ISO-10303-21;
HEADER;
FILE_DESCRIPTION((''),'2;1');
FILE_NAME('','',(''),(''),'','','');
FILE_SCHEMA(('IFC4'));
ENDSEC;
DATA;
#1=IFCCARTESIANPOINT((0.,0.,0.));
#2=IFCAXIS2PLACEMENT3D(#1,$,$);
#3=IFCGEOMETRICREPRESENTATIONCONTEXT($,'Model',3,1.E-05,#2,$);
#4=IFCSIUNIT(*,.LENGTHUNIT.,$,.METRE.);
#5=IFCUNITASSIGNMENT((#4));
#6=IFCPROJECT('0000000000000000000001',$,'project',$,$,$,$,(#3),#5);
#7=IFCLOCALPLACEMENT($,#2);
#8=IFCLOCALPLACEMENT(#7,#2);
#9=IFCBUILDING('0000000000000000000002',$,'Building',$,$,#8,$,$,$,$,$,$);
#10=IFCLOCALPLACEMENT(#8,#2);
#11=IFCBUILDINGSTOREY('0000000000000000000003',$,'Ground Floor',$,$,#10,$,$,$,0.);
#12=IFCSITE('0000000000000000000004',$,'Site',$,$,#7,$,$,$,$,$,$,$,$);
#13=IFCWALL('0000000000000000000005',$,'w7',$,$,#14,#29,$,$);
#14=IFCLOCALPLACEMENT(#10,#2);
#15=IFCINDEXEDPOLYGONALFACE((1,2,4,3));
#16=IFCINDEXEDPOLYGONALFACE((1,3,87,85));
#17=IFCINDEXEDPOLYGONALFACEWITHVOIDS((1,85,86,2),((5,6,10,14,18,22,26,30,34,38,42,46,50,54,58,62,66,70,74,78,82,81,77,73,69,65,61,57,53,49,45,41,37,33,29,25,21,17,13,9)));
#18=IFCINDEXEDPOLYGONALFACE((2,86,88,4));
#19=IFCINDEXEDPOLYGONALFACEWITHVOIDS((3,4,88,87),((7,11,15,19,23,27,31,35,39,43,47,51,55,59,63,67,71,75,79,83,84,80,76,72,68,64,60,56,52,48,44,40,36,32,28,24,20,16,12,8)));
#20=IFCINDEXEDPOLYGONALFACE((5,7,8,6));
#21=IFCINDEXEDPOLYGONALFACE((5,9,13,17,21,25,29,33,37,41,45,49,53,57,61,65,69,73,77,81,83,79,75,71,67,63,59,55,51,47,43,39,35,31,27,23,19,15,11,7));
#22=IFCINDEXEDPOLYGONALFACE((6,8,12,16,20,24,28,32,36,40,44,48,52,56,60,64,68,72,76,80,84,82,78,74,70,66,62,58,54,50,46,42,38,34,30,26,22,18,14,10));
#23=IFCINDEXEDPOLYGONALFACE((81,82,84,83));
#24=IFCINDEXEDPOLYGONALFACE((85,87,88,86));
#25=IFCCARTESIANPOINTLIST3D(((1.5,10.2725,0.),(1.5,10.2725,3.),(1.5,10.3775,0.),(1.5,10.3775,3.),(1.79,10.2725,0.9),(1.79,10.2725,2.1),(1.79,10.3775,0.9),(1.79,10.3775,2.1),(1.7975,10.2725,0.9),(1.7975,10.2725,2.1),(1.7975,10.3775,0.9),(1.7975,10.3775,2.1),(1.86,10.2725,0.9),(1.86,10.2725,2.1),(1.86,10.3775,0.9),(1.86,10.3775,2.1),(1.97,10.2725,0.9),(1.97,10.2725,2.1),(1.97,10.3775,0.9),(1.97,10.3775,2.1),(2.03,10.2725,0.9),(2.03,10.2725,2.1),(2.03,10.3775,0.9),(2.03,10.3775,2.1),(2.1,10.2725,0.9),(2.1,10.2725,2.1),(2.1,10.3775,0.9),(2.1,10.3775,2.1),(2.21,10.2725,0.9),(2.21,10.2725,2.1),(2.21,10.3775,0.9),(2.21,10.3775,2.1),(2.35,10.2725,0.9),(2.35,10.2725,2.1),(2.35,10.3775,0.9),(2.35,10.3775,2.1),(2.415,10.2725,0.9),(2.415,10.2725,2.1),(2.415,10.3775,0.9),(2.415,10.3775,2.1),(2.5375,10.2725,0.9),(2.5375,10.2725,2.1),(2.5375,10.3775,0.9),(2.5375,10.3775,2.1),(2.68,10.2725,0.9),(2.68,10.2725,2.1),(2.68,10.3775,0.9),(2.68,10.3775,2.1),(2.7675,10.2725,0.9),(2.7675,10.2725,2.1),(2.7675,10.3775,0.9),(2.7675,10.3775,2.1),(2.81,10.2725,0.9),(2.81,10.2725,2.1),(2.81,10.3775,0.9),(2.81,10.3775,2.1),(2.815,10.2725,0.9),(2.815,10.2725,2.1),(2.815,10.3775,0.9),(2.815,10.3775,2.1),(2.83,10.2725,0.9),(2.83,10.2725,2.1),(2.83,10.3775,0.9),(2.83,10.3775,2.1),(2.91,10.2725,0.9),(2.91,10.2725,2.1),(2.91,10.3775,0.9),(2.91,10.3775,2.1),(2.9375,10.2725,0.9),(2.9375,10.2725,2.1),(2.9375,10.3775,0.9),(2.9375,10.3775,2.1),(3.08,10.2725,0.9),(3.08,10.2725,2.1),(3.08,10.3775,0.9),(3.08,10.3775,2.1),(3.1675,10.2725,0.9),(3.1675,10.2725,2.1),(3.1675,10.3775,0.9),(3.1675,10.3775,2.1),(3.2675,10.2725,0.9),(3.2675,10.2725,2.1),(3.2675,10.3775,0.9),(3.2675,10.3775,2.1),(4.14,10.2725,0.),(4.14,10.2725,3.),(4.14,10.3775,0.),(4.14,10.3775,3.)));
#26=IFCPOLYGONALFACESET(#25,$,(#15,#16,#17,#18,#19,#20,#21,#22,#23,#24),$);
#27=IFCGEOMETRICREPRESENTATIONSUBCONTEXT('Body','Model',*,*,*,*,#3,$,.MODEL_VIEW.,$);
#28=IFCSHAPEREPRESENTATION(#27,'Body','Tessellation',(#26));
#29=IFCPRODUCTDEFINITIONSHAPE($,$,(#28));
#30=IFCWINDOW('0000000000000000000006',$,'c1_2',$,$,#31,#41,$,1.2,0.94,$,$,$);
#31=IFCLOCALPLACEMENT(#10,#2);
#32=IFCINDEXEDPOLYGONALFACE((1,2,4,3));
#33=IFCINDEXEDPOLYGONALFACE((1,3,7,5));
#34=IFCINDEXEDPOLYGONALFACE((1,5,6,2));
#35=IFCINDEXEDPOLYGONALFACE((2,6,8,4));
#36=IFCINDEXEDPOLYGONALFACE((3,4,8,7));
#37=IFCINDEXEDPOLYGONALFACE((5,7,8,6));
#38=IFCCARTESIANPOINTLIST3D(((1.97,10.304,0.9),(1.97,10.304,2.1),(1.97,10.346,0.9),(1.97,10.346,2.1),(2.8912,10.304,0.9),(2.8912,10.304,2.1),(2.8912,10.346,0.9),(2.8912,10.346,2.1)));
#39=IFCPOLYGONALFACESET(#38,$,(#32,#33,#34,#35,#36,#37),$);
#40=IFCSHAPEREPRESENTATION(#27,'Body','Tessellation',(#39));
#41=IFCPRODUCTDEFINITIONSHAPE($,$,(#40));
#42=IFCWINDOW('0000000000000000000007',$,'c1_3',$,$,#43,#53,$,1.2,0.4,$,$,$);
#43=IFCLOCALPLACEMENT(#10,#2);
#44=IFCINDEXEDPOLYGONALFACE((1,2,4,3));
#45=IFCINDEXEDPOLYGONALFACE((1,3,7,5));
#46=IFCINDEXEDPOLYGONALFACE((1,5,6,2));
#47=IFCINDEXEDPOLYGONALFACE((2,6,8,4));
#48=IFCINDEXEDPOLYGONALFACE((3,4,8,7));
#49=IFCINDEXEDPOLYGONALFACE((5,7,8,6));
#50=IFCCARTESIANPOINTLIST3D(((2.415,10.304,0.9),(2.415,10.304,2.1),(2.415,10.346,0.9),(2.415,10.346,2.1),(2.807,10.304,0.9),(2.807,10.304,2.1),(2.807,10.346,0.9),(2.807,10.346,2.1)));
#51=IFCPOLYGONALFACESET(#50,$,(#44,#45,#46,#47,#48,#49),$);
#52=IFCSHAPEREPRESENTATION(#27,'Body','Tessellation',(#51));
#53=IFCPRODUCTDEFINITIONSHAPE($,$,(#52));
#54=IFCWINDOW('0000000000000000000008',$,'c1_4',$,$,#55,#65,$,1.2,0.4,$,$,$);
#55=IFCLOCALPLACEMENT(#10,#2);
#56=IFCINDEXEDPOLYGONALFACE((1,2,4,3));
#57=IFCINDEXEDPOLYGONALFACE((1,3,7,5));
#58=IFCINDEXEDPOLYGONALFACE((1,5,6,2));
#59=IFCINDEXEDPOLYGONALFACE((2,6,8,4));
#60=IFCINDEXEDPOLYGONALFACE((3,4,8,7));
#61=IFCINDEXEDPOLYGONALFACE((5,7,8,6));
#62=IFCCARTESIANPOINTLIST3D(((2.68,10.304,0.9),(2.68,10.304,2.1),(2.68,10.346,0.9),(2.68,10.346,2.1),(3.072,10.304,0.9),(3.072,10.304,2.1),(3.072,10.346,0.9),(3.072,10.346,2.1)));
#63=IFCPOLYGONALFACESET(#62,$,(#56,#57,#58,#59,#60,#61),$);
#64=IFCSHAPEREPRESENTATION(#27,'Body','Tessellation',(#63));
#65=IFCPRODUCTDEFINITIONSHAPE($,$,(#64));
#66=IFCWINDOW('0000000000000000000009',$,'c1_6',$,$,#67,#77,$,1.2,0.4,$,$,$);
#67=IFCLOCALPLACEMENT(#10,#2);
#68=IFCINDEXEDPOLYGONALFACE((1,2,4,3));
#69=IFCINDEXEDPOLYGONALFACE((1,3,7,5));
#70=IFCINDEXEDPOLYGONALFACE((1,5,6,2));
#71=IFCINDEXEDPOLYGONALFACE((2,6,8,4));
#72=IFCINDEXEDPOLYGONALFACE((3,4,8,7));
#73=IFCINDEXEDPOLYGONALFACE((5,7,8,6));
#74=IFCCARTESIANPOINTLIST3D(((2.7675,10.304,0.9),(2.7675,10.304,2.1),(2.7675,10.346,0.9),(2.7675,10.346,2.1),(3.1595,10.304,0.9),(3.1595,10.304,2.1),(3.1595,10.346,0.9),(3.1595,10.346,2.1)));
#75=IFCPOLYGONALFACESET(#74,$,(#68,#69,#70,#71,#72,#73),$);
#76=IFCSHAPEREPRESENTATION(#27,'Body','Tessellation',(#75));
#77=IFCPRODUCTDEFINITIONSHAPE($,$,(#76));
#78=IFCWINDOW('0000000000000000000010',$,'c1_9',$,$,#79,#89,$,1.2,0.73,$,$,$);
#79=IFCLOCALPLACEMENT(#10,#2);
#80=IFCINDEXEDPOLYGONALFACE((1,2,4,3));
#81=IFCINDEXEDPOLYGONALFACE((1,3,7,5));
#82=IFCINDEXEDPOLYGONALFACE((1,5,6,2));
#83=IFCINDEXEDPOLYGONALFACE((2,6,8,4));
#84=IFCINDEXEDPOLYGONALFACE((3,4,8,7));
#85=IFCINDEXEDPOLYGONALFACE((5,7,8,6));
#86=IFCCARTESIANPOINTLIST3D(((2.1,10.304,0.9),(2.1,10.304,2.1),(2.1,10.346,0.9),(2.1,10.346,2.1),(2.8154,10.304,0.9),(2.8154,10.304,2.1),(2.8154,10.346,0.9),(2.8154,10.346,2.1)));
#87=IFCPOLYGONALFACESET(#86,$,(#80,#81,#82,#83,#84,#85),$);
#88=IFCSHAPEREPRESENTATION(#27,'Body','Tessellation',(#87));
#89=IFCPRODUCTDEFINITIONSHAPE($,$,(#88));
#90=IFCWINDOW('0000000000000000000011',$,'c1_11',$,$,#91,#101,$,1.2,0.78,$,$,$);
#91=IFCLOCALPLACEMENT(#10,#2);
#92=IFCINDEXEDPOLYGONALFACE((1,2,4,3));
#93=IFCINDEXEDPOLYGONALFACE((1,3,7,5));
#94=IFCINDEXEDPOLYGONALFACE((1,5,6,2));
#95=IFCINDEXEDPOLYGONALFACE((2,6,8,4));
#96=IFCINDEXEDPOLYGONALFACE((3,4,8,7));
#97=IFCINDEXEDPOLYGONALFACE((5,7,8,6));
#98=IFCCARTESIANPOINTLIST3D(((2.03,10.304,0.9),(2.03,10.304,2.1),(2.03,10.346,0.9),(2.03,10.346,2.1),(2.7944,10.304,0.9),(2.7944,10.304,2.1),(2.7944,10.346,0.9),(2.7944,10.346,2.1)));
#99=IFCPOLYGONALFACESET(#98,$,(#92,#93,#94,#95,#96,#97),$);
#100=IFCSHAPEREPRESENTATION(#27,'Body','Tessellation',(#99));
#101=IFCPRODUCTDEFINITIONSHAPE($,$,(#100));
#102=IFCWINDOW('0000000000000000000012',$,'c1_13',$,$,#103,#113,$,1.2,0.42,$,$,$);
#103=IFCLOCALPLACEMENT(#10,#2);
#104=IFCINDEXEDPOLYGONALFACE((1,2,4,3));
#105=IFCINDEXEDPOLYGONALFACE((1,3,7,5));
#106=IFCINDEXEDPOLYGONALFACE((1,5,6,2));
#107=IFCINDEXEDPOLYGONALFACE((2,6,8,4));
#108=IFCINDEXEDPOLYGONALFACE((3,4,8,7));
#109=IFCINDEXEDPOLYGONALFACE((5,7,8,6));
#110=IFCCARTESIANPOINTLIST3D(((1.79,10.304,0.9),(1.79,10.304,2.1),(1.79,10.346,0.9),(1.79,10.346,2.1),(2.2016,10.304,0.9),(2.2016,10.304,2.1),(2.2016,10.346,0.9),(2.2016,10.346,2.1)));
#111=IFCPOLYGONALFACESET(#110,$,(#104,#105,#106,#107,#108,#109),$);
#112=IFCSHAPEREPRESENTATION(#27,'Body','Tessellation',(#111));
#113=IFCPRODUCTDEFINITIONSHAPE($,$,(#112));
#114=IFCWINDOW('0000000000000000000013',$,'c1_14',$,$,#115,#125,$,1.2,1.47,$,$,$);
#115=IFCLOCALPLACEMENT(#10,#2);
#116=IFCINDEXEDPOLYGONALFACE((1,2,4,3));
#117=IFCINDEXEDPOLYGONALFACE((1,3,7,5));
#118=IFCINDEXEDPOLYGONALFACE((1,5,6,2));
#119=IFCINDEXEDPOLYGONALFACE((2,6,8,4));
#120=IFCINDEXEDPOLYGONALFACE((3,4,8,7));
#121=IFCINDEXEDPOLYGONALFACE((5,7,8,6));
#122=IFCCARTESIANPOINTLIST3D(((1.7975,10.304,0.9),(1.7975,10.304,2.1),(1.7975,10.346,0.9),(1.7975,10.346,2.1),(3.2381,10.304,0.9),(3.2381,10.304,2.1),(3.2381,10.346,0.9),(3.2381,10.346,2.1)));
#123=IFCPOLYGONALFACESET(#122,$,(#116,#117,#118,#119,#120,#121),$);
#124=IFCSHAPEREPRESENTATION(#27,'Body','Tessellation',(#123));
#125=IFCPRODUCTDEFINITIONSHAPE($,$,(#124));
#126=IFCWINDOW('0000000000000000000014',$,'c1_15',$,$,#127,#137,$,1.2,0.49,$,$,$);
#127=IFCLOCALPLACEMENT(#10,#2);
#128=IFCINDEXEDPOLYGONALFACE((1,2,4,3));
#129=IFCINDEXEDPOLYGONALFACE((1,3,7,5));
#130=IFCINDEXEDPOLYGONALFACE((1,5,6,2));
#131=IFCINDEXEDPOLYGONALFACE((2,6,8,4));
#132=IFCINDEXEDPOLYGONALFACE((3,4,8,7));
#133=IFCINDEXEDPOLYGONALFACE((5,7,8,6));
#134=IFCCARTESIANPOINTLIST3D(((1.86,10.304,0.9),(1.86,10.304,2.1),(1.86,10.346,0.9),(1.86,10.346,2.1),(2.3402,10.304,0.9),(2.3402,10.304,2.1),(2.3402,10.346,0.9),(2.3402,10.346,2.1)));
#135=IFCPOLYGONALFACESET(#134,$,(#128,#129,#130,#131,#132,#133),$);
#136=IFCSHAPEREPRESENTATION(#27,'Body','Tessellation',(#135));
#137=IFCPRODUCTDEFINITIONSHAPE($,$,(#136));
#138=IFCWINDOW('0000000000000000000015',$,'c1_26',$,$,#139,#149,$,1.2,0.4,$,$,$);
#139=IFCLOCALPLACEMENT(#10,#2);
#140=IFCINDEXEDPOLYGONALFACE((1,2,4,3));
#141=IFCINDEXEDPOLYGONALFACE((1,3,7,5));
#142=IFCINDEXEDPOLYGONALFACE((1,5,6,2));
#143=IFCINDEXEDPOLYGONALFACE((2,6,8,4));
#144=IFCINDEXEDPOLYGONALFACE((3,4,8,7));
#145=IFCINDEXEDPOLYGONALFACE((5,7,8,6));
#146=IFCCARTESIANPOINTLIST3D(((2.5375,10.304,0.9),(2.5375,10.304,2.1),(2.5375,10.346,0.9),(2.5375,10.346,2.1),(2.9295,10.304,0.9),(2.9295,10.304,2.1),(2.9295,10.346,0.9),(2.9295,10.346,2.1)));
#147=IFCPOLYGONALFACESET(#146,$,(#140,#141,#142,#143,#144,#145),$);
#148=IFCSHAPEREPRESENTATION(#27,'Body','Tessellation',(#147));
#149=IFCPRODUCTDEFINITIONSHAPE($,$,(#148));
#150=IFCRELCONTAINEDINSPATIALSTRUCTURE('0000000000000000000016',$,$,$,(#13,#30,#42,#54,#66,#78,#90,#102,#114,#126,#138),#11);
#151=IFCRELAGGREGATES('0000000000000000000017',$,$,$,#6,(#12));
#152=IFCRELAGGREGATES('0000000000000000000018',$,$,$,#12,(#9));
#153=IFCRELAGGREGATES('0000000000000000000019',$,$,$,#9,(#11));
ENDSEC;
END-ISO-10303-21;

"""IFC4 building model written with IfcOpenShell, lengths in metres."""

from ifc_helpers import new_model, si_unit, frame, origin, place, context, subcontext, project, spatial, polyline, outline, extrude, element, fill, save


model = new_model("IFC4")

# Units and contexts
model_context = context("Model", 3, precision=1e-05, world=origin())
body_context = subcontext(model_context, "Body", "Model", "MODEL_VIEW")
ifc_project = project(units=[si_unit("LENGTHUNIT", "METRE")], contexts=[model_context])

# Site, building, storey
site_placement = place(None, origin())
site = spatial("IfcSite", under=ifc_project, at=site_placement, Name="Site")
building_placement = place(site_placement, origin())
building = spatial("IfcBuilding", under=site, at=building_placement, Name="Building")
storey_placement = place(building_placement, origin())
storey = spatial("IfcBuildingStorey", under=building, at=storey_placement, Name="Ground Floor", Elevation=0.0)

# Wall, openings, windows
wall_1_placement = place(storey_placement, frame((1.5, 10.325, 0.0), x_axis=(1.0, 0.0, 0.0)))
wall_1 = element("IfcWall", 1, at=wall_1_placement, inside=storey, Name="w7", context=body_context, shape_type="SweptSolid", body=[
    extrude(outline(polyline([(0.0, -0.0525), (2.64, -0.0525), (2.64, 0.0525), (0.0, 0.0525), (0.0, -0.0525)])), origin(), (0.0, 0.0, 1.0), 3.0),
])
opening_1_placement = place(wall_1_placement, frame((0.47, 0.0, 0.0)))
opening_1 = element("IfcOpeningElement", 2, at=opening_1_placement, cuts=wall_1, context=body_context, shape_type="SweptSolid", body=[
    extrude(outline(polyline([(0.0, -0.0551), (0.94, -0.0551), (0.94, 0.0551), (0.0, 0.0551), (0.0, -0.0551)])), frame((0.0, 0.0, 0.9)), (0.0, 0.0, 1.0), 1.2),
])
opening_2_placement = place(wall_1_placement, frame((0.915, 0.0, 0.0)))
opening_2 = element("IfcOpeningElement", 3, at=opening_2_placement, cuts=wall_1, context=body_context, shape_type="SweptSolid", body=[
    extrude(outline(polyline([(0.0, -0.0551), (0.4, -0.0551), (0.4, 0.0551), (0.0, 0.0551), (0.0, -0.0551)])), frame((0.0, 0.0, 0.9)), (0.0, 0.0, 1.0), 1.2),
])
opening_3_placement = place(wall_1_placement, frame((1.18, 0.0, 0.0)))
opening_3 = element("IfcOpeningElement", 4, at=opening_3_placement, cuts=wall_1, context=body_context, shape_type="SweptSolid", body=[
    extrude(outline(polyline([(0.0, -0.0551), (0.4, -0.0551), (0.4, 0.0551), (0.0, 0.0551), (0.0, -0.0551)])), frame((0.0, 0.0, 0.9)), (0.0, 0.0, 1.0), 1.2),
])
opening_4_placement = place(wall_1_placement, frame((1.2675, 0.0, 0.0)))
opening_4 = element("IfcOpeningElement", 5, at=opening_4_placement, cuts=wall_1, context=body_context, shape_type="SweptSolid", body=[
    extrude(outline(polyline([(0.0, -0.0551), (0.4, -0.0551), (0.4, 0.0551), (0.0, 0.0551), (0.0, -0.0551)])), frame((0.0, 0.0, 0.9)), (0.0, 0.0, 1.0), 1.2),
])
opening_5_placement = place(wall_1_placement, frame((0.6, 0.0, 0.0)))
opening_5 = element("IfcOpeningElement", 6, at=opening_5_placement, cuts=wall_1, context=body_context, shape_type="SweptSolid", body=[
    extrude(outline(polyline([(0.0, -0.0551), (0.73, -0.0551), (0.73, 0.0551), (0.0, 0.0551), (0.0, -0.0551)])), frame((0.0, 0.0, 0.9)), (0.0, 0.0, 1.0), 1.2),
])
opening_6_placement = place(wall_1_placement, frame((0.53, 0.0, 0.0)))
opening_6 = element("IfcOpeningElement", 7, at=opening_6_placement, cuts=wall_1, context=body_context, shape_type="SweptSolid", body=[
    extrude(outline(polyline([(0.0, -0.0551), (0.78, -0.0551), (0.78, 0.0551), (0.0, 0.0551), (0.0, -0.0551)])), frame((0.0, 0.0, 0.9)), (0.0, 0.0, 1.0), 1.2),
])
opening_7_placement = place(wall_1_placement, frame((0.29, 0.0, 0.0)))
opening_7 = element("IfcOpeningElement", 8, at=opening_7_placement, cuts=wall_1, context=body_context, shape_type="SweptSolid", body=[
    extrude(outline(polyline([(0.0, -0.0551), (0.42, -0.0551), (0.42, 0.0551), (0.0, 0.0551), (0.0, -0.0551)])), frame((0.0, 0.0, 0.9)), (0.0, 0.0, 1.0), 1.2),
])
opening_8_placement = place(wall_1_placement, frame((0.2975, 0.0, 0.0)))
opening_8 = element("IfcOpeningElement", 9, at=opening_8_placement, cuts=wall_1, context=body_context, shape_type="SweptSolid", body=[
    extrude(outline(polyline([(0.0, -0.0551), (1.47, -0.0551), (1.47, 0.0551), (0.0, 0.0551), (0.0, -0.0551)])), frame((0.0, 0.0, 0.9)), (0.0, 0.0, 1.0), 1.2),
])
opening_9_placement = place(wall_1_placement, frame((0.36, 0.0, 0.0)))
opening_9 = element("IfcOpeningElement", 10, at=opening_9_placement, cuts=wall_1, context=body_context, shape_type="SweptSolid", body=[
    extrude(outline(polyline([(0.0, -0.0551), (0.49, -0.0551), (0.49, 0.0551), (0.0, 0.0551), (0.0, -0.0551)])), frame((0.0, 0.0, 0.9)), (0.0, 0.0, 1.0), 1.2),
])
opening_10_placement = place(wall_1_placement, frame((1.0375, 0.0, 0.0)))
opening_10 = element("IfcOpeningElement", 11, at=opening_10_placement, cuts=wall_1, context=body_context, shape_type="SweptSolid", body=[
    extrude(outline(polyline([(0.0, -0.0551), (0.4, -0.0551), (0.4, 0.0551), (0.0, 0.0551), (0.0, -0.0551)])), frame((0.0, 0.0, 0.9)), (0.0, 0.0, 1.0), 1.2),
])
window_1_placement = place(wall_1_placement, frame((0.47, 0.0, 0.0)))
window_1 = element("IfcWindow", 12, at=window_1_placement, inside=storey, Name="c1_2", OverallHeight=1.2, OverallWidth=0.94, context=body_context, shape_type="SweptSolid", body=[
    extrude(outline(polyline([(0.0, -0.021), (0.9212, -0.021), (0.9212, 0.021), (0.0, 0.021), (0.0, -0.021)])), frame((0.0, 0.0, 0.9)), (0.0, 0.0, 1.0), 1.2),
])
fill(opening_1, window_1)
window_2_placement = place(wall_1_placement, frame((0.915, 0.0, 0.0)))
window_2 = element("IfcWindow", 13, at=window_2_placement, inside=storey, Name="c1_3", OverallHeight=1.2, OverallWidth=0.4, context=body_context, shape_type="SweptSolid", body=[
    extrude(outline(polyline([(0.0, -0.021), (0.392, -0.021), (0.392, 0.021), (0.0, 0.021), (0.0, -0.021)])), frame((0.0, 0.0, 0.9)), (0.0, 0.0, 1.0), 1.2),
])
fill(opening_2, window_2)
window_3_placement = place(wall_1_placement, frame((1.18, 0.0, 0.0)))
window_3 = element("IfcWindow", 14, at=window_3_placement, inside=storey, Name="c1_4", OverallHeight=1.2, OverallWidth=0.4, context=body_context, shape_type="SweptSolid", body=[
    extrude(outline(polyline([(0.0, -0.021), (0.392, -0.021), (0.392, 0.021), (0.0, 0.021), (0.0, -0.021)])), frame((0.0, 0.0, 0.9)), (0.0, 0.0, 1.0), 1.2),
])
fill(opening_3, window_3)
window_4_placement = place(wall_1_placement, frame((1.2675, 0.0, 0.0)))
window_4 = element("IfcWindow", 15, at=window_4_placement, inside=storey, Name="c1_6", OverallHeight=1.2, OverallWidth=0.4, context=body_context, shape_type="SweptSolid", body=[
    extrude(outline(polyline([(0.0, -0.021), (0.392, -0.021), (0.392, 0.021), (0.0, 0.021), (0.0, -0.021)])), frame((0.0, 0.0, 0.9)), (0.0, 0.0, 1.0), 1.2),
])
fill(opening_4, window_4)
window_5_placement = place(wall_1_placement, frame((0.6, 0.0, 0.0)))
window_5 = element("IfcWindow", 16, at=window_5_placement, inside=storey, Name="c1_9", OverallHeight=1.2, OverallWidth=0.73, context=body_context, shape_type="SweptSolid", body=[
    extrude(outline(polyline([(0.0, -0.021), (0.7154, -0.021), (0.7154, 0.021), (0.0, 0.021), (0.0, -0.021)])), frame((0.0, 0.0, 0.9)), (0.0, 0.0, 1.0), 1.2),
])
fill(opening_5, window_5)
window_6_placement = place(wall_1_placement, frame((0.53, 0.0, 0.0)))
window_6 = element("IfcWindow", 17, at=window_6_placement, inside=storey, Name="c1_11", OverallHeight=1.2, OverallWidth=0.78, context=body_context, shape_type="SweptSolid", body=[
    extrude(outline(polyline([(0.0, -0.021), (0.7644, -0.021), (0.7644, 0.021), (0.0, 0.021), (0.0, -0.021)])), frame((0.0, 0.0, 0.9)), (0.0, 0.0, 1.0), 1.2),
])
fill(opening_6, window_6)
window_7_placement = place(wall_1_placement, frame((0.29, 0.0, 0.0)))
window_7 = element("IfcWindow", 18, at=window_7_placement, inside=storey, Name="c1_13", OverallHeight=1.2, OverallWidth=0.42, context=body_context, shape_type="SweptSolid", body=[
    extrude(outline(polyline([(0.0, -0.021), (0.4116, -0.021), (0.4116, 0.021), (0.0, 0.021), (0.0, -0.021)])), frame((0.0, 0.0, 0.9)), (0.0, 0.0, 1.0), 1.2),
])
fill(opening_7, window_7)
window_8_placement = place(wall_1_placement, frame((0.2975, 0.0, 0.0)))
window_8 = element("IfcWindow", 19, at=window_8_placement, inside=storey, Name="c1_14", OverallHeight=1.2, OverallWidth=1.47, context=body_context, shape_type="SweptSolid", body=[
    extrude(outline(polyline([(0.0, -0.021), (1.4406, -0.021), (1.4406, 0.021), (0.0, 0.021), (0.0, -0.021)])), frame((0.0, 0.0, 0.9)), (0.0, 0.0, 1.0), 1.2),
])
fill(opening_8, window_8)
window_9_placement = place(wall_1_placement, frame((0.36, 0.0, 0.0)))
window_9 = element("IfcWindow", 20, at=window_9_placement, inside=storey, Name="c1_15", OverallHeight=1.2, OverallWidth=0.49, context=body_context, shape_type="SweptSolid", body=[
    extrude(outline(polyline([(0.0, -0.021), (0.4802, -0.021), (0.4802, 0.021), (0.0, 0.021), (0.0, -0.021)])), frame((0.0, 0.0, 0.9)), (0.0, 0.0, 1.0), 1.2),
])
fill(opening_9, window_9)
window_10_placement = place(wall_1_placement, frame((1.0375, 0.0, 0.0)))
window_10 = element("IfcWindow", 21, at=window_10_placement, inside=storey, Name="c1_26", OverallHeight=1.2, OverallWidth=0.4, context=body_context, shape_type="SweptSolid", body=[
    extrude(outline(polyline([(0.0, -0.021), (0.392, -0.021), (0.392, 0.021), (0.0, 0.021), (0.0, -0.021)])), frame((0.0, 0.0, 0.9)), (0.0, 0.0, 1.0), 1.2),
])
fill(opening_10, window_10)

save(model, "model.ifc")
